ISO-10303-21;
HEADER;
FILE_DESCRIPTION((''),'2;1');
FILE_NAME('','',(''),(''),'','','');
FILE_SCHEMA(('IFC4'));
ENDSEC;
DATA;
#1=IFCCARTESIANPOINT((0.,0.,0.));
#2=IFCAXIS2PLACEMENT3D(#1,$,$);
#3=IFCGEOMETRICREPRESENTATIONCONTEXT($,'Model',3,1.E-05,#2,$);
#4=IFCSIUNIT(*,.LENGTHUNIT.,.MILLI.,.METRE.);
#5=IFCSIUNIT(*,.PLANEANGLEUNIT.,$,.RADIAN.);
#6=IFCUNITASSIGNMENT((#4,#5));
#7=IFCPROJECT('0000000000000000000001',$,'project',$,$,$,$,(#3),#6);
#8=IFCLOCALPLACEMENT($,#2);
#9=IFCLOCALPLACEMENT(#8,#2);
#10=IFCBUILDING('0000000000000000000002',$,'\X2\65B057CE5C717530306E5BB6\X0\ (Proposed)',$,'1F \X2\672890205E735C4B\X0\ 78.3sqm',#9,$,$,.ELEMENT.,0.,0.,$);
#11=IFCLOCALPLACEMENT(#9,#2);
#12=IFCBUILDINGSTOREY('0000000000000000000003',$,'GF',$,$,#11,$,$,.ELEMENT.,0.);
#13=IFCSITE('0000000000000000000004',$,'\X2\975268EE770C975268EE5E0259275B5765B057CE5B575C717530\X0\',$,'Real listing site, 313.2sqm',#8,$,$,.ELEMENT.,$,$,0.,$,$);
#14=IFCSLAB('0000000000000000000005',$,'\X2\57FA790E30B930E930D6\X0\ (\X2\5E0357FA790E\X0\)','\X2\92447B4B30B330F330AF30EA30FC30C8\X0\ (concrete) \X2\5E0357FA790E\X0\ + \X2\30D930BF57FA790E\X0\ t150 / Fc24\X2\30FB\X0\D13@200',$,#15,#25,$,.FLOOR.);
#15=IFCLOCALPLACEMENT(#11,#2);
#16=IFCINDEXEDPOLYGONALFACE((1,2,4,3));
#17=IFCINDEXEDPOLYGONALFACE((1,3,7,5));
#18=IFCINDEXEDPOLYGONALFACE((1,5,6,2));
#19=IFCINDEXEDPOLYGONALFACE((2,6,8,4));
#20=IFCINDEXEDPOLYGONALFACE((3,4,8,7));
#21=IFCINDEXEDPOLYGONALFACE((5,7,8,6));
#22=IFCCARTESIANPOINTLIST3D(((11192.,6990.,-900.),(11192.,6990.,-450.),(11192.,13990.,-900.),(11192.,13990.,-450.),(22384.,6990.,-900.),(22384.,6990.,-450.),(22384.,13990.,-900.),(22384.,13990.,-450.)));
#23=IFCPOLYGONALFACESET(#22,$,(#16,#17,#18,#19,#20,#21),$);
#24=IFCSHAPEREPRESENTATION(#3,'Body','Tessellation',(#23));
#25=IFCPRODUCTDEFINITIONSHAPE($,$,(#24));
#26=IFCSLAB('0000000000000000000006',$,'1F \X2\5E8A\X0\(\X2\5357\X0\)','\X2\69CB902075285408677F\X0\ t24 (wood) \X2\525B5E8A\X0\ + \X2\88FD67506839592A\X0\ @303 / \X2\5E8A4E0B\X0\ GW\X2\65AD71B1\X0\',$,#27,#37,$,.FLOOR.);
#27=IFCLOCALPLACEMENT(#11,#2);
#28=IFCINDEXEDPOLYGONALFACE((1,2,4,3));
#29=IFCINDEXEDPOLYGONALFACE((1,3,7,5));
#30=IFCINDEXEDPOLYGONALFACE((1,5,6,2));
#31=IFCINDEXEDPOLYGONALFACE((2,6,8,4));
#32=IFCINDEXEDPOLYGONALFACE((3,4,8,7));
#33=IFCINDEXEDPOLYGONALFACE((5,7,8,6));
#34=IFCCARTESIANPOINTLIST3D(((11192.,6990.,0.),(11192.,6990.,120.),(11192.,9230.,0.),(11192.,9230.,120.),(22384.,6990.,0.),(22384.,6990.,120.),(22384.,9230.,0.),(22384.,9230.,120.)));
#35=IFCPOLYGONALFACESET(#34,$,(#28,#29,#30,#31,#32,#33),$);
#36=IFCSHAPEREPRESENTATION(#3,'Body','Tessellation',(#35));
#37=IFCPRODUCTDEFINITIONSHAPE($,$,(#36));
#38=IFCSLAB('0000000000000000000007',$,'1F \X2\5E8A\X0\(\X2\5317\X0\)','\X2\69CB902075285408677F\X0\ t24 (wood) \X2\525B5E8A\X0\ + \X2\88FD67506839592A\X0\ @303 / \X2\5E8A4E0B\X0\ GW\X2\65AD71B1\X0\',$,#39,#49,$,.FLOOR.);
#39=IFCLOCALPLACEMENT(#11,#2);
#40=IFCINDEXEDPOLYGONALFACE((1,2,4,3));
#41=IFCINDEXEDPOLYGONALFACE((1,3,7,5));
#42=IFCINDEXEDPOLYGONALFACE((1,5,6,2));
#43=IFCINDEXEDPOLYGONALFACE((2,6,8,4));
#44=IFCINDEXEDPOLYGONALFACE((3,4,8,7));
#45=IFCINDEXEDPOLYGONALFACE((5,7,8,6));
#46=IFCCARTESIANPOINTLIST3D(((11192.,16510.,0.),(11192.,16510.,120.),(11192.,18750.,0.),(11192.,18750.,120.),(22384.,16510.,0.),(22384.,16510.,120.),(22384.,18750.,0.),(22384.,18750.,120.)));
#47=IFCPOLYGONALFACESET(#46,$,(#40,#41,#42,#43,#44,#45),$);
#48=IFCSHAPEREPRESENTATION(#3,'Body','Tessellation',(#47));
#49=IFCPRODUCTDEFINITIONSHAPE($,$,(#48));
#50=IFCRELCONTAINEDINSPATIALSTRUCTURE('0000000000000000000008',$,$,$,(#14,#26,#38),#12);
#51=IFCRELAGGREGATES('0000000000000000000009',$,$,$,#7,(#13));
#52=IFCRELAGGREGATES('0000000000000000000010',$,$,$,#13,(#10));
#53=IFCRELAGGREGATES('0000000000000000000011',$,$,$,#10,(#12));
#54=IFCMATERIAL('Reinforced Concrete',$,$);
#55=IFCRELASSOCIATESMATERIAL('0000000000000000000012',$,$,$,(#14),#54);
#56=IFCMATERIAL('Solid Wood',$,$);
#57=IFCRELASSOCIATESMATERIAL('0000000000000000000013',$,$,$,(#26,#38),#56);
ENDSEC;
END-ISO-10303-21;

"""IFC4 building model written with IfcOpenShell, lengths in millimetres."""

from ifc_helpers import new_model, si_unit, frame, frame_2d, origin, place, context, project, spatial, rectangle, extrude, material, element, save


model = new_model("IFC4")

# Units and contexts
model_context = context("Model", 3, precision=1e-05, world=origin())
ifc_project = project(units=[si_unit("LENGTHUNIT", "METRE", prefix="MILLI"), si_unit("PLANEANGLEUNIT", "RADIAN")], contexts=[model_context])

# Site, building, storey
site_placement = place(None, origin())
site = spatial("IfcSite", under=ifc_project, at=site_placement, Name="青森県青森市大字新城字山田", ObjectType="Real listing site, 313.2sqm", CompositionType="ELEMENT", RefElevation=0.0)
building_placement = place(site_placement, origin())
building = spatial("IfcBuilding", under=site, at=building_placement, Name="新城山田の家 (Proposed)", ObjectType="1F 木造平屋 78.3sqm", CompositionType="ELEMENT", ElevationOfRefHeight=0.0, ElevationOfTerrain=0.0)
storey_placement = place(building_placement, origin())
storey = spatial("IfcBuildingStorey", under=building, at=storey_placement, Name="GF", CompositionType="ELEMENT", Elevation=0.0)

# Slabs
ifc_material_1 = material(Name="Reinforced Concrete")
slab_1_placement = place(storey_placement, frame((5596.0, 3495.0, -450.0)))
element("IfcSlab", 1, at=slab_1_placement, inside=storey, material=ifc_material_1, Name="基礎スラブ (布基礎)", Description="鉄筋コンクリート (concrete) 布基礎 + ベタ基礎 t150 / Fc24・D13@200", PredefinedType="FLOOR", context=model_context, shape_type="SweptSolid", body=[
    extrude(rectangle(XDim=11192.0, YDim=7000.0, at=frame_2d((5596.0, 3500.0))), frame((5596.0, 3495.0, -450.0)), (0.0, 0.0, 1.0), 450.0),
])
ifc_material_2 = material(Name="Solid Wood")
slab_2_placement = place(storey_placement, frame((5596.0, 3495.0, 0.0)))
element("IfcSlab", 2, at=slab_2_placement, inside=storey, material=ifc_material_2, Name="1F 床(南)", Description="構造用合板 t24 (wood) 剛床 + 製材根太 @303 / 床下 GW断熱", PredefinedType="FLOOR", context=model_context, shape_type="SweptSolid", body=[
    extrude(rectangle(XDim=11192.0, YDim=2240.0, at=frame_2d((5596.0, 1120.0))), frame((5596.0, 3495.0, 0.0)), (0.0, 0.0, 1.0), 120.0),
])
slab_3_placement = place(storey_placement, frame((5596.0, 8255.0, 0.0)))
element("IfcSlab", 3, at=slab_3_placement, inside=storey, material=ifc_material_2, Name="1F 床(北)", Description="構造用合板 t24 (wood) 剛床 + 製材根太 @303 / 床下 GW断熱", PredefinedType="FLOOR", context=model_context, shape_type="SweptSolid", body=[
    extrude(rectangle(XDim=11192.0, YDim=2240.0, at=frame_2d((5596.0, 1120.0))), frame((5596.0, 8255.0, 0.0)), (0.0, 0.0, 1.0), 120.0),
])

save(model, "model.ifc")
